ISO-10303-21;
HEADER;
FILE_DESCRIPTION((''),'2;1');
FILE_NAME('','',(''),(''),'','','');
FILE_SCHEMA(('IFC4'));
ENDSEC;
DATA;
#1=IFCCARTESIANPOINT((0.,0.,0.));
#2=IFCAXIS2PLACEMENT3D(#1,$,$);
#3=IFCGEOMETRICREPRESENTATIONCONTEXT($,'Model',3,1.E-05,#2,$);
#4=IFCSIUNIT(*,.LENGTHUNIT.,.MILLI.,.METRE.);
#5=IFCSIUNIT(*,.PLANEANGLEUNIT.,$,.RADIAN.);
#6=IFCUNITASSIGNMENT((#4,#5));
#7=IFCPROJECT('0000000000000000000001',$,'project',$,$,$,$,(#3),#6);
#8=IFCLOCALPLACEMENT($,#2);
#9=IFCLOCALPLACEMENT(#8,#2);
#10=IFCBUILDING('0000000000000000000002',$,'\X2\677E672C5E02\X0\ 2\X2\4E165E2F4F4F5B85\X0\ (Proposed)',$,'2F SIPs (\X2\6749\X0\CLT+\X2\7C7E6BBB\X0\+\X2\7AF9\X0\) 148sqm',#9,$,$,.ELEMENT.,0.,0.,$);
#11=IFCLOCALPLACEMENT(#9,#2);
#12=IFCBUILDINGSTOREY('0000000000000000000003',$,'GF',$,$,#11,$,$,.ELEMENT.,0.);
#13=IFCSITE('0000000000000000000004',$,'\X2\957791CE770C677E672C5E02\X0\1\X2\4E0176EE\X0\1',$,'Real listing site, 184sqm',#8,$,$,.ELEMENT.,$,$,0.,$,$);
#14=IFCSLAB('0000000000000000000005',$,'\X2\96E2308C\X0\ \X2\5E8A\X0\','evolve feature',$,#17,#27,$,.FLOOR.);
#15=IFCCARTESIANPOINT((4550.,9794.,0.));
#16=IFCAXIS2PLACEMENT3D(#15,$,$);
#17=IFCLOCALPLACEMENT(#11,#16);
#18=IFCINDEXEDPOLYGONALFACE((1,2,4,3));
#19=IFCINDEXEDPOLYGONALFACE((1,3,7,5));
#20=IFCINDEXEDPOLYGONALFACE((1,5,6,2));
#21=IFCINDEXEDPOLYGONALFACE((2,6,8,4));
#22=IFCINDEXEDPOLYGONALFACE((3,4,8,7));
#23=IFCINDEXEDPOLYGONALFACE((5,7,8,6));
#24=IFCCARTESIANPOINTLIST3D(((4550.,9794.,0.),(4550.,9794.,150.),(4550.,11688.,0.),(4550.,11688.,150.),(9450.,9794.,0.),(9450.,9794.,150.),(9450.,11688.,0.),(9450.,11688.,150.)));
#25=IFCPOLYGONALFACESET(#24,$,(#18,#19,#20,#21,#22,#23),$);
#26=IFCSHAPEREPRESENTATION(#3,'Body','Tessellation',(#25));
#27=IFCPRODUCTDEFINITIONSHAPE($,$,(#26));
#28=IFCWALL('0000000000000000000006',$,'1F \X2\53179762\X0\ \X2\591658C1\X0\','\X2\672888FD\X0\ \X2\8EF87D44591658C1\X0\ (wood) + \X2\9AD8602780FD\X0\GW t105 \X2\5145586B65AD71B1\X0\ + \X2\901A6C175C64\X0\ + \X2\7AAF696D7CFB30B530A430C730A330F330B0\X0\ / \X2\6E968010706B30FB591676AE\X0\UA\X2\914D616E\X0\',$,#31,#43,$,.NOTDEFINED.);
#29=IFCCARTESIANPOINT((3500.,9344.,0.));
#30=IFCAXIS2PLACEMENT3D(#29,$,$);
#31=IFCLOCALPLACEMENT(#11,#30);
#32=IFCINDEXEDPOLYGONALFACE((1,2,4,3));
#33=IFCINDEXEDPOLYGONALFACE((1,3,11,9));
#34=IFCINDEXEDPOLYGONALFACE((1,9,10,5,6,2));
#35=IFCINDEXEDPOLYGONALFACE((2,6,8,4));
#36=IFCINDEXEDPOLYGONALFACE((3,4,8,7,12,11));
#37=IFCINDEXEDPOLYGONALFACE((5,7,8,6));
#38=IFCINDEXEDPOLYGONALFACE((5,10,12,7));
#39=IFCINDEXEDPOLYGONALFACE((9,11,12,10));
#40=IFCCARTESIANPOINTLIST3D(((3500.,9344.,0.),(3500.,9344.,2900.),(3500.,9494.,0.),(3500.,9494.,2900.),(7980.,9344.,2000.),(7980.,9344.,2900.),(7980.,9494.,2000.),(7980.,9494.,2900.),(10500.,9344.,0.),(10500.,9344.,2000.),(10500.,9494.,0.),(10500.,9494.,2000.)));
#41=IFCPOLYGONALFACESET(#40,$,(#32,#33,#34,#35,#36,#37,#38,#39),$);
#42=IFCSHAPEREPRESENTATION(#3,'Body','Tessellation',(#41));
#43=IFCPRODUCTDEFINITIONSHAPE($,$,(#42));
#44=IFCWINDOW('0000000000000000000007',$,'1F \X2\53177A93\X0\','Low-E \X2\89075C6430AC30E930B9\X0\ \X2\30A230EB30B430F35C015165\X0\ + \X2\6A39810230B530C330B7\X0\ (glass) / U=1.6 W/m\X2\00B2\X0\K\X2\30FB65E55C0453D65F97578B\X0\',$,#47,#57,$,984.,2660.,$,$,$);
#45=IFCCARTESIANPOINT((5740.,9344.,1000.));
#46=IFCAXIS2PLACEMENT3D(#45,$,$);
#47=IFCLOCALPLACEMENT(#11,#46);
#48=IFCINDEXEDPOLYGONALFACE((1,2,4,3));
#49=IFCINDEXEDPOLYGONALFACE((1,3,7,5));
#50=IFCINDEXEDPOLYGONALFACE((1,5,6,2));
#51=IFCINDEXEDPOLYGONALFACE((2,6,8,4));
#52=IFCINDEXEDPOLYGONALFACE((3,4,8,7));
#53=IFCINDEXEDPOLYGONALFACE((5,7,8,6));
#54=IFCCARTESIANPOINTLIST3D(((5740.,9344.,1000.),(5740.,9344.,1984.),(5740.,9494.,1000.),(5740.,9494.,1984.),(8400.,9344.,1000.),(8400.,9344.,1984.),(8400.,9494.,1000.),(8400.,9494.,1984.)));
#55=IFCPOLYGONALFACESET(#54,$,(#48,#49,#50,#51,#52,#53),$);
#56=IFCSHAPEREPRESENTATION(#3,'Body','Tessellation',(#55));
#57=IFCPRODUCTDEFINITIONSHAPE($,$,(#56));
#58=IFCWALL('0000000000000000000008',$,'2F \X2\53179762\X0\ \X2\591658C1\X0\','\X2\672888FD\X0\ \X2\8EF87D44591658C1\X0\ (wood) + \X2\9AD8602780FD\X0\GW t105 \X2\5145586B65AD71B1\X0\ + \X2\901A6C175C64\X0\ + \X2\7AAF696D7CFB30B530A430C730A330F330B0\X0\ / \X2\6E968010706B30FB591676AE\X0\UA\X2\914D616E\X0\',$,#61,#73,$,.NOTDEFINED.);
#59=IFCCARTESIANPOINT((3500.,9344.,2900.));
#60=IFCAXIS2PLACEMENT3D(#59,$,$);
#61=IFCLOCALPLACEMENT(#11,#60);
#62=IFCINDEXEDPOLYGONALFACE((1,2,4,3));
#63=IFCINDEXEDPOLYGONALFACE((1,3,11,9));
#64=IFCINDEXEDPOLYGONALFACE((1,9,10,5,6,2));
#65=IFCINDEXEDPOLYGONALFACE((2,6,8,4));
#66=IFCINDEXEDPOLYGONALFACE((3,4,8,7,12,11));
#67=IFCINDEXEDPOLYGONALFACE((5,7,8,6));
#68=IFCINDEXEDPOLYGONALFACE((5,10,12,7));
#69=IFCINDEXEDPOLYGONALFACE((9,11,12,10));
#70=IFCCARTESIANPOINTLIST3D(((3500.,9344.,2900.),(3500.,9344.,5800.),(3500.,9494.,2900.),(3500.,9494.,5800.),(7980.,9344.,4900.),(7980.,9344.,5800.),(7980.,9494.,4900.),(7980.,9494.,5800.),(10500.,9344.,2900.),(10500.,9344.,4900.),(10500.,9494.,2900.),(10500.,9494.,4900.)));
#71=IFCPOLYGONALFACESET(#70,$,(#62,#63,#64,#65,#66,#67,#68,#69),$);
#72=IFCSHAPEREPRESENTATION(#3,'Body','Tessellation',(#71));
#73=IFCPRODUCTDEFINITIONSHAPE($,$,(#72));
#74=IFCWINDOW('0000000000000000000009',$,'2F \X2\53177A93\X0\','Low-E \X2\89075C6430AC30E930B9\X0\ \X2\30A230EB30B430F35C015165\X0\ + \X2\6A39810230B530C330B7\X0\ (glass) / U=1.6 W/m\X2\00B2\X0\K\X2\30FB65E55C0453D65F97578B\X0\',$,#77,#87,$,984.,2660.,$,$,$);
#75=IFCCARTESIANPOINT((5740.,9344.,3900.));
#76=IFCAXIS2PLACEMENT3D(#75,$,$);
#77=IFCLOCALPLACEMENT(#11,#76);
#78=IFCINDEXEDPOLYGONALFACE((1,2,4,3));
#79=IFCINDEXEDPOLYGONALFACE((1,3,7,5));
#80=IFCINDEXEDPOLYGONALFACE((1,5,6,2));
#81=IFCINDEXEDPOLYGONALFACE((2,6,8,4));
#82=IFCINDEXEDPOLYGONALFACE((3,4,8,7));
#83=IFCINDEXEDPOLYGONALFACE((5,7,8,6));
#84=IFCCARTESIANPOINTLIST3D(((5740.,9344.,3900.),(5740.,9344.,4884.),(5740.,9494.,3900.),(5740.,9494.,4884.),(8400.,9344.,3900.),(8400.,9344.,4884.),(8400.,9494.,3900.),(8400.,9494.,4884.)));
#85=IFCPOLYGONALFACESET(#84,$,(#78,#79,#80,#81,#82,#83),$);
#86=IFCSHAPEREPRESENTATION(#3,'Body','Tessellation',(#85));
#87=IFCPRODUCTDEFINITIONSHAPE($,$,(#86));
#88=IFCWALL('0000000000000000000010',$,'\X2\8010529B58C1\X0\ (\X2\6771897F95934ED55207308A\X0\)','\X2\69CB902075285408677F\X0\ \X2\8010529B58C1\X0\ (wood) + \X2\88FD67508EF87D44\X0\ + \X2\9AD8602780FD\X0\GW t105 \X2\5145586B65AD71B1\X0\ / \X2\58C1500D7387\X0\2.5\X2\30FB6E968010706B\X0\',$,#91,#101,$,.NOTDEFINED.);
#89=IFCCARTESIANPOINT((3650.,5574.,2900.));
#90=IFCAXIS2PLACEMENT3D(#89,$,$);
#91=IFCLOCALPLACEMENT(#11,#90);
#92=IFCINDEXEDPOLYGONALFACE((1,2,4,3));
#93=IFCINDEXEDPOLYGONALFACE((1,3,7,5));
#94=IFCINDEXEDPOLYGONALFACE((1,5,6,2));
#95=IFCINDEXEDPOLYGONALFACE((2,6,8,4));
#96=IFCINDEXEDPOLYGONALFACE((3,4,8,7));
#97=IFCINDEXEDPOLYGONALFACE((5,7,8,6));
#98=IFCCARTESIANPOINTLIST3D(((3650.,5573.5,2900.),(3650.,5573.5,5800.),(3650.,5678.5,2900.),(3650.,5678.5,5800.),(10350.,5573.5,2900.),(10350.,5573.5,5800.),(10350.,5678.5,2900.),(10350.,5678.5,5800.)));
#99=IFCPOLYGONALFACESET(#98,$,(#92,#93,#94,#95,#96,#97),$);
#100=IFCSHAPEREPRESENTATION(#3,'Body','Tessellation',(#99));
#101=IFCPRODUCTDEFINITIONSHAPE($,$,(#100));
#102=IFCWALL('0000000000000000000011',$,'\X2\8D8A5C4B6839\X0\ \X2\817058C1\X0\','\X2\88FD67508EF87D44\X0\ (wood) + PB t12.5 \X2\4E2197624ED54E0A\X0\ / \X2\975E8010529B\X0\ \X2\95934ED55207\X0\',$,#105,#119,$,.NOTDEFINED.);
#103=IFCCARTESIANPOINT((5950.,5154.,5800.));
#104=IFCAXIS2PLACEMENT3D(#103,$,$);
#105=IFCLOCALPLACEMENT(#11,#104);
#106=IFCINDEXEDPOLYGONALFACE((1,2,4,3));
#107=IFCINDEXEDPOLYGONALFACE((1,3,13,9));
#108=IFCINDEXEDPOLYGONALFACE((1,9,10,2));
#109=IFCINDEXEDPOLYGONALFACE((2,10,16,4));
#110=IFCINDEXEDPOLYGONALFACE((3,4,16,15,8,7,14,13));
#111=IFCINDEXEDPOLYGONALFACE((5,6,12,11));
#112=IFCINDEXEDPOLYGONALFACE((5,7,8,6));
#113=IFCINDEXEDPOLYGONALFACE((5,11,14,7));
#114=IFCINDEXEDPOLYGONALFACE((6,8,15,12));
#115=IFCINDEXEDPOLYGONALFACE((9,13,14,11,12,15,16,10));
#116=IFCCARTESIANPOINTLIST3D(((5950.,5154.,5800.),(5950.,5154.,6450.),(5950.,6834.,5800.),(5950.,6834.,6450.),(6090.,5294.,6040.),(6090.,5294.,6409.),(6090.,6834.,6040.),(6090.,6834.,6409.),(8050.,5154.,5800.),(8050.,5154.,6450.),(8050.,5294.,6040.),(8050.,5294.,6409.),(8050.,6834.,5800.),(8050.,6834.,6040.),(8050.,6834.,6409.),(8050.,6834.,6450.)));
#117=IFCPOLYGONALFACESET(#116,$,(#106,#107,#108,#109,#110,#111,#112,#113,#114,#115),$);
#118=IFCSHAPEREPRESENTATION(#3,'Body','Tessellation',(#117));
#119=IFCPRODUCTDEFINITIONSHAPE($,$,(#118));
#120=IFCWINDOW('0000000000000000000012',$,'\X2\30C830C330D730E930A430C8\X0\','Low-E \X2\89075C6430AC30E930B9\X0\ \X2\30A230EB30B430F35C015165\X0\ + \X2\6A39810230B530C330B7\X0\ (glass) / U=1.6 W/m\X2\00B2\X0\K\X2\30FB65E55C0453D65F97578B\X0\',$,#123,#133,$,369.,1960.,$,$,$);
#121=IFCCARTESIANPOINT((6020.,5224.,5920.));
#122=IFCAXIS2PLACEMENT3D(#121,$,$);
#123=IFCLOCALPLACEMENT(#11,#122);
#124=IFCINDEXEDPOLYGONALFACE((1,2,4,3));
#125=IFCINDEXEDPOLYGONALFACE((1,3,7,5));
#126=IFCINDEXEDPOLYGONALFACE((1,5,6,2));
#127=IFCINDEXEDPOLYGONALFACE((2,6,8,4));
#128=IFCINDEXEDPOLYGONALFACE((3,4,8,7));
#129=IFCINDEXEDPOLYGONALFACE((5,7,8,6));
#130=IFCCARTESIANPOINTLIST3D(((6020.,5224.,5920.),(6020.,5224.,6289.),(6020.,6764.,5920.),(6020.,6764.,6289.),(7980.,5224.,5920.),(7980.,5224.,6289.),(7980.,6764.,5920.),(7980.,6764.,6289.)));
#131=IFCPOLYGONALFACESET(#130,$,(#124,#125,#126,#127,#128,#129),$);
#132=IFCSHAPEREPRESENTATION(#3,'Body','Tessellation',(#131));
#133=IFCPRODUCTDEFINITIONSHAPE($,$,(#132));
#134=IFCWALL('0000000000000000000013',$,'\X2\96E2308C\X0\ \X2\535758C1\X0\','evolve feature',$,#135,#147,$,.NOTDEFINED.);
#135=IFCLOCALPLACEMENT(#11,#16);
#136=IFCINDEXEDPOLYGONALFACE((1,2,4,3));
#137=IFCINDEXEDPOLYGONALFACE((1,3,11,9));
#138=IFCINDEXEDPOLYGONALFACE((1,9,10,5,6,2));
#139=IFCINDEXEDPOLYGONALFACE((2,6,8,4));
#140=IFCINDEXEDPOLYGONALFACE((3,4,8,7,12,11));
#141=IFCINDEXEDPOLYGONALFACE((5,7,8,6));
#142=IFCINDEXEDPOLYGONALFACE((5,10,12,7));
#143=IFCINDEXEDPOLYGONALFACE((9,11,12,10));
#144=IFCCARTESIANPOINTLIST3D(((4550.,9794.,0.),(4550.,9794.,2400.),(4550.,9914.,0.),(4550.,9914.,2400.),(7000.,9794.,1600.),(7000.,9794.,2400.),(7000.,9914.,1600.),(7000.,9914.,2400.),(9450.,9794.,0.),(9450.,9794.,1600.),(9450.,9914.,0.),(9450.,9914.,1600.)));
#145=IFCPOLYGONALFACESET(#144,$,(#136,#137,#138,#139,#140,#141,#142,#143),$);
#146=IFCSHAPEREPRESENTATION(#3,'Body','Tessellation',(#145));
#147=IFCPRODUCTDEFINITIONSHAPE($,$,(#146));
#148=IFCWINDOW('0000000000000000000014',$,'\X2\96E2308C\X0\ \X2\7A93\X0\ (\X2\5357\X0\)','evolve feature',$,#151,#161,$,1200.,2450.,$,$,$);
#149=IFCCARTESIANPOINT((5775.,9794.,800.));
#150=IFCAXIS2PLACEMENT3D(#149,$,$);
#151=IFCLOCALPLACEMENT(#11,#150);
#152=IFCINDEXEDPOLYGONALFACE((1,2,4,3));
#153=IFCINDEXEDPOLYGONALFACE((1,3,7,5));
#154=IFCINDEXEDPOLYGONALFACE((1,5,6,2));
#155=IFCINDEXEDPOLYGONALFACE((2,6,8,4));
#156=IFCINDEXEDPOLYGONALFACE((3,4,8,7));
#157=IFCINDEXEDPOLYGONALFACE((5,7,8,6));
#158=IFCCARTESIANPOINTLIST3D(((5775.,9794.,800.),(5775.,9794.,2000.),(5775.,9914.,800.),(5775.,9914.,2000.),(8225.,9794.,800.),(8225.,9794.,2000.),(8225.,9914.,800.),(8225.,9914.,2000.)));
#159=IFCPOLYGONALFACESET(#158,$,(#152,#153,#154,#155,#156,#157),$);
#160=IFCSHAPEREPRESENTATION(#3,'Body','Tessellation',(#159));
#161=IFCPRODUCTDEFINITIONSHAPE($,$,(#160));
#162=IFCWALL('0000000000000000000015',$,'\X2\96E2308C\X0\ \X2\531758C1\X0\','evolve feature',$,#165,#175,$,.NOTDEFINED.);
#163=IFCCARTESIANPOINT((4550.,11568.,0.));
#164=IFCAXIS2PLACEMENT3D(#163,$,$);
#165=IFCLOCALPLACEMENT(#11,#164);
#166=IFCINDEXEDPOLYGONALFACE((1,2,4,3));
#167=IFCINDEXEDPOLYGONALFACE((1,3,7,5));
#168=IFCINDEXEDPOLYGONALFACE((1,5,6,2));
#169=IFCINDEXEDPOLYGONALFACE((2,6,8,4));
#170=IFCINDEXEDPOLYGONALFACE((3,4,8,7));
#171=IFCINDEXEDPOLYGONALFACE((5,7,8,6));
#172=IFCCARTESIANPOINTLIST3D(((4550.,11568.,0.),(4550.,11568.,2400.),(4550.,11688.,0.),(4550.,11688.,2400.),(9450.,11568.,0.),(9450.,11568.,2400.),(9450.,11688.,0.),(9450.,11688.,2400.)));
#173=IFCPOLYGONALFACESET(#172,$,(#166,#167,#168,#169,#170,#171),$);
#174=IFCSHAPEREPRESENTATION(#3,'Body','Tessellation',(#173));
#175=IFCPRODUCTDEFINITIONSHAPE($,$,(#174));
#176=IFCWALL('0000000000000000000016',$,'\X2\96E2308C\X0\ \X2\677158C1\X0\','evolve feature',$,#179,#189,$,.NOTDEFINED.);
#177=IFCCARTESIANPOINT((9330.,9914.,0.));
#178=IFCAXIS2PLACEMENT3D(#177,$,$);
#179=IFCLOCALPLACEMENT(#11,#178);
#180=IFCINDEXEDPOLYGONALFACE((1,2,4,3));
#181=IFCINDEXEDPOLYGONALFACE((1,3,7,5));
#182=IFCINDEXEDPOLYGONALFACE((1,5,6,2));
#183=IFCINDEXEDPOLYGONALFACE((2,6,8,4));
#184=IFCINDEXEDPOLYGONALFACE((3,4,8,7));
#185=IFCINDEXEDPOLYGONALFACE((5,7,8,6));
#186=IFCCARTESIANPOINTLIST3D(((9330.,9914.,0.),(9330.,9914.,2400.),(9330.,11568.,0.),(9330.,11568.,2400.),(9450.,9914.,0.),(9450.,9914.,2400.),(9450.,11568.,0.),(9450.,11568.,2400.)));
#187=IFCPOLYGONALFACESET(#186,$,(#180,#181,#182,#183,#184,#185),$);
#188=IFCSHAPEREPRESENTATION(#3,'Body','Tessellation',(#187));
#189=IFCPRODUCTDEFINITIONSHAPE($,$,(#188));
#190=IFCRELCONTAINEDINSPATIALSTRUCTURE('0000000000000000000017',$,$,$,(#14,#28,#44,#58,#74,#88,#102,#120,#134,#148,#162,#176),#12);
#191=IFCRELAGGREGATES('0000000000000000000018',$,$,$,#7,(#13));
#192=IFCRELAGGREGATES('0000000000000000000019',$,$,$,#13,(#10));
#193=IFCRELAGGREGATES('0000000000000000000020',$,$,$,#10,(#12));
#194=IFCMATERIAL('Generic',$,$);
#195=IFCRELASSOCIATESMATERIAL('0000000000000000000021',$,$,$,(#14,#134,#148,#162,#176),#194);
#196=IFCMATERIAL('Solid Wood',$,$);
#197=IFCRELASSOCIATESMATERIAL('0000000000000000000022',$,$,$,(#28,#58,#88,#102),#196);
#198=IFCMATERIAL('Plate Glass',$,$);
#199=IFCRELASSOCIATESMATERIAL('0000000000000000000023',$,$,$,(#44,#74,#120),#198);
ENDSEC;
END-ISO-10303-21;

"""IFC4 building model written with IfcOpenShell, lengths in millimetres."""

from ifc_helpers import new_model, si_unit, frame, frame_2d, origin, place, context, project, spatial, rectangle, extrude, material, element, fill, save


model = new_model("IFC4")

# Units and contexts
model_context = context("Model", 3, precision=1e-05, world=origin())
ifc_project = project(units=[si_unit("LENGTHUNIT", "METRE", prefix="MILLI"), si_unit("PLANEANGLEUNIT", "RADIAN")], contexts=[model_context])

# Site, building, storey
site_placement = place(None, origin())
site = spatial("IfcSite", under=ifc_project, at=site_placement, Name="長野県松本市1丁目1", ObjectType="Real listing site, 184sqm", CompositionType="ELEMENT", RefElevation=0.0)
building_placement = place(site_placement, origin())
building = spatial("IfcBuilding", under=site, at=building_placement, Name="松本市 2世帯住宅 (Proposed)", ObjectType="2F SIPs (杉CLT+籾殻+竹) 148sqm", CompositionType="ELEMENT", ElevationOfRefHeight=0.0, ElevationOfTerrain=0.0)
storey_placement = place(building_placement, origin())
storey = spatial("IfcBuildingStorey", under=building, at=storey_placement, Name="GF", CompositionType="ELEMENT", Elevation=0.0)

# Slab
ifc_material_1 = material(Name="Generic")
slab_placement = place(storey_placement, frame((4550.0, 9794.0, 0.0)))
element("IfcSlab", 1, at=slab_placement, inside=storey, material=ifc_material_1, Name="離れ 床", Description="evolve feature", PredefinedType="FLOOR", context=model_context, shape_type="SweptSolid", body=[
    extrude(rectangle(XDim=4900.0, YDim=1894.0, at=frame_2d((2450.0, 947.0))), frame((4550.0, 9794.0, 0.0)), (0.0, 0.0, 1.0), 150.0),
])

# Wall, opening, window
ifc_material_2 = material(Name="Solid Wood")
wall_1_placement = place(storey_placement, frame((3500.0, 9344.0, 0.0)))
wall_1 = element("IfcWall", 2, at=wall_1_placement, inside=storey, material=ifc_material_2, Name="1F 北面 外壁", Description="木製 軸組外壁 (wood) + 高性能GW t105 充填断熱 + 通気層 + 窯業系サイディング / 準耐火・外皮UA配慮", PredefinedType="NOTDEFINED", context=model_context, shape_type="SweptSolid", body=[
    extrude(rectangle(XDim=7000.0, YDim=150.0, at=frame_2d((3500.0, 75.0))), frame((3500.0, 9344.0, 0.0)), (0.0, 0.0, 1.0), 2900.0),
])
opening_1_placement = place(storey_placement, frame((5740.0, 9344.0, 1000.0)))
opening_1 = element("IfcOpeningElement", 3, at=opening_1_placement, cuts=wall_1, PredefinedType="NOTDEFINED", context=model_context, shape_type="SweptSolid", body=[
    extrude(rectangle(XDim=2660.0, YDim=150.0, at=frame_2d((1330.0, 75.0))), frame((5740.0, 9344.0, 1000.0)), (0.0, 0.0, 1.0), 984.0),
])
ifc_material_3 = material(Name="Plate Glass")
window_1_placement = place(storey_placement, frame((5740.0, 9344.0, 1000.0)))
window_1 = element("IfcWindow", 4, at=window_1_placement, inside=storey, material=ifc_material_3, Name="1F 北窓", Description="Low-E 複層ガラス アルゴン封入 + 樹脂サッシ (glass) / U=1.6 W/m²K・日射取得型", OverallHeight=984.0, OverallWidth=2660.0, context=model_context, shape_type="SweptSolid", body=[
    extrude(rectangle(XDim=2660.0, YDim=150.0, at=frame_2d((1330.0, 75.0))), frame((5740.0, 9344.0, 1000.0)), (0.0, 0.0, 1.0), 984.0),
])
fill(opening_1, window_1)

# Wall, opening, window
wall_2_placement = place(storey_placement, frame((3500.0, 9344.0, 2900.0)))
wall_2 = element("IfcWall", 5, at=wall_2_placement, inside=storey, material=ifc_material_2, Name="2F 北面 外壁", Description="木製 軸組外壁 (wood) + 高性能GW t105 充填断熱 + 通気層 + 窯業系サイディング / 準耐火・外皮UA配慮", PredefinedType="NOTDEFINED", context=model_context, shape_type="SweptSolid", body=[
    extrude(rectangle(XDim=7000.0, YDim=150.0, at=frame_2d((3500.0, 75.0))), frame((3500.0, 9344.0, 2900.0)), (0.0, 0.0, 1.0), 2900.0),
])
opening_2_placement = place(storey_placement, frame((5740.0, 9344.0, 3900.0)))
opening_2 = element("IfcOpeningElement", 6, at=opening_2_placement, cuts=wall_2, PredefinedType="NOTDEFINED", context=model_context, shape_type="SweptSolid", body=[
    extrude(rectangle(XDim=2660.0, YDim=150.0, at=frame_2d((1330.0, 75.0))), frame((5740.0, 9344.0, 3900.0)), (0.0, 0.0, 1.0), 984.0),
])
window_2_placement = place(storey_placement, frame((5740.0, 9344.0, 3900.0)))
window_2 = element("IfcWindow", 7, at=window_2_placement, inside=storey, material=ifc_material_3, Name="2F 北窓", Description="Low-E 複層ガラス アルゴン封入 + 樹脂サッシ (glass) / U=1.6 W/m²K・日射取得型", OverallHeight=984.0, OverallWidth=2660.0, context=model_context, shape_type="SweptSolid", body=[
    extrude(rectangle(XDim=2660.0, YDim=150.0, at=frame_2d((1330.0, 75.0))), frame((5740.0, 9344.0, 3900.0)), (0.0, 0.0, 1.0), 984.0),
])
fill(opening_2, window_2)

# Wall
wall_3_placement = place(storey_placement, frame((3650.0, 5574.0, 2900.0)))
element("IfcWall", 8, at=wall_3_placement, inside=storey, material=ifc_material_2, Name="耐力壁 (東西間仕切り)", Description="構造用合板 耐力壁 (wood) + 製材軸組 + 高性能GW t105 充填断熱 / 壁倍率2.5・準耐火", PredefinedType="NOTDEFINED", context=model_context, shape_type="SweptSolid", body=[
    extrude(rectangle(XDim=6700.0, YDim=105.0, at=frame_2d((3350.0, 52.0))), frame((3650.0, 5574.0, 2900.0)), (0.0, 0.0, 1.0), 2900.0),
])

# Walls, openings, windows
wall_4_placement = place(storey_placement, frame((5950.0, 5154.0, 5800.0)))
wall_4 = element("IfcWall", 9, at=wall_4_placement, inside=storey, material=ifc_material_2, Name="越屋根 腰壁", Description="製材軸組 (wood) + PB t12.5 両面仕上 / 非耐力 間仕切", PredefinedType="NOTDEFINED", context=model_context, shape_type="SweptSolid", body=[
    extrude(rectangle(XDim=2100.0, YDim=1680.0, at=frame_2d((1050.0, 840.0))), frame((5950.0, 5154.0, 5800.0)), (0.0, 0.0, 1.0), 650.0),
])
opening_3_placement = place(storey_placement, frame((6020.0, 5224.0, 5920.0)))
opening_3 = element("IfcOpeningElement", 10, at=opening_3_placement, cuts=wall_4, PredefinedType="NOTDEFINED", context=model_context, shape_type="SweptSolid", body=[
    extrude(rectangle(XDim=1960.0, YDim=1540.0, at=frame_2d((980.0, 770.0))), frame((6020.0, 5224.0, 5920.0)), (0.0, 0.0, 1.0), 369.0),
])
window_3_placement = place(storey_placement, frame((6020.0, 5224.0, 5920.0)))
window_3 = element("IfcWindow", 11, at=window_3_placement, inside=storey, material=ifc_material_3, Name="トップライト", Description="Low-E 複層ガラス アルゴン封入 + 樹脂サッシ (glass) / U=1.6 W/m²K・日射取得型", OverallHeight=369.0, OverallWidth=1960.0, context=model_context, shape_type="SweptSolid", body=[
    extrude(rectangle(XDim=1960.0, YDim=1540.0, at=frame_2d((980.0, 770.0))), frame((6020.0, 5224.0, 5920.0)), (0.0, 0.0, 1.0), 369.0),
])
fill(opening_3, window_3)
wall_5_placement = place(storey_placement, frame((4550.0, 9794.0, 0.0)))
wall_5 = element("IfcWall", 12, at=wall_5_placement, inside=storey, material=ifc_material_1, Name="離れ 南壁", Description="evolve feature", PredefinedType="NOTDEFINED", context=model_context, shape_type="SweptSolid", body=[
    extrude(rectangle(XDim=4900.0, YDim=120.0, at=frame_2d((2450.0, 60.0))), frame((4550.0, 9794.0, 0.0)), (0.0, 0.0, 1.0), 2400.0),
])
opening_4_placement = place(storey_placement, frame((5775.0, 9794.0, 800.0)))
opening_4 = element("IfcOpeningElement", 13, at=opening_4_placement, cuts=wall_5, PredefinedType="NOTDEFINED", context=model_context, shape_type="SweptSolid", body=[
    extrude(rectangle(XDim=2450.0, YDim=120.0, at=frame_2d((1225.0, 60.0))), frame((5775.0, 9794.0, 800.0)), (0.0, 0.0, 1.0), 1200.0),
])
window_4_placement = place(storey_placement, frame((5775.0, 9794.0, 800.0)))
window_4 = element("IfcWindow", 14, at=window_4_placement, inside=storey, material=ifc_material_1, Name="離れ 窓 (南)", Description="evolve feature", OverallHeight=1200.0, OverallWidth=2450.0, context=model_context, shape_type="SweptSolid", body=[
    extrude(rectangle(XDim=2450.0, YDim=120.0, at=frame_2d((1225.0, 60.0))), frame((5775.0, 9794.0, 800.0)), (0.0, 0.0, 1.0), 1200.0),
])
fill(opening_4, window_4)

# Walls
wall_6_placement = place(storey_placement, frame((4550.0, 11568.0, 0.0)))
element("IfcWall", 15, at=wall_6_placement, inside=storey, material=ifc_material_1, Name="離れ 北壁", Description="evolve feature", PredefinedType="NOTDEFINED", context=model_context, shape_type="SweptSolid", body=[
    extrude(rectangle(XDim=4900.0, YDim=120.0, at=frame_2d((2450.0, 60.0))), frame((4550.0, 11568.0, 0.0)), (0.0, 0.0, 1.0), 2400.0),
])
wall_7_placement = place(storey_placement, frame((9330.0, 9914.0, 0.0)))
element("IfcWall", 16, at=wall_7_placement, inside=storey, material=ifc_material_1, Name="離れ 東壁", Description="evolve feature", PredefinedType="NOTDEFINED", context=model_context, shape_type="SweptSolid", body=[
    extrude(rectangle(XDim=120.0, YDim=1654.0, at=frame_2d((60.0, 827.0))), frame((9330.0, 9914.0, 0.0)), (0.0, 0.0, 1.0), 2400.0),
])

save(model, "model.ifc")
